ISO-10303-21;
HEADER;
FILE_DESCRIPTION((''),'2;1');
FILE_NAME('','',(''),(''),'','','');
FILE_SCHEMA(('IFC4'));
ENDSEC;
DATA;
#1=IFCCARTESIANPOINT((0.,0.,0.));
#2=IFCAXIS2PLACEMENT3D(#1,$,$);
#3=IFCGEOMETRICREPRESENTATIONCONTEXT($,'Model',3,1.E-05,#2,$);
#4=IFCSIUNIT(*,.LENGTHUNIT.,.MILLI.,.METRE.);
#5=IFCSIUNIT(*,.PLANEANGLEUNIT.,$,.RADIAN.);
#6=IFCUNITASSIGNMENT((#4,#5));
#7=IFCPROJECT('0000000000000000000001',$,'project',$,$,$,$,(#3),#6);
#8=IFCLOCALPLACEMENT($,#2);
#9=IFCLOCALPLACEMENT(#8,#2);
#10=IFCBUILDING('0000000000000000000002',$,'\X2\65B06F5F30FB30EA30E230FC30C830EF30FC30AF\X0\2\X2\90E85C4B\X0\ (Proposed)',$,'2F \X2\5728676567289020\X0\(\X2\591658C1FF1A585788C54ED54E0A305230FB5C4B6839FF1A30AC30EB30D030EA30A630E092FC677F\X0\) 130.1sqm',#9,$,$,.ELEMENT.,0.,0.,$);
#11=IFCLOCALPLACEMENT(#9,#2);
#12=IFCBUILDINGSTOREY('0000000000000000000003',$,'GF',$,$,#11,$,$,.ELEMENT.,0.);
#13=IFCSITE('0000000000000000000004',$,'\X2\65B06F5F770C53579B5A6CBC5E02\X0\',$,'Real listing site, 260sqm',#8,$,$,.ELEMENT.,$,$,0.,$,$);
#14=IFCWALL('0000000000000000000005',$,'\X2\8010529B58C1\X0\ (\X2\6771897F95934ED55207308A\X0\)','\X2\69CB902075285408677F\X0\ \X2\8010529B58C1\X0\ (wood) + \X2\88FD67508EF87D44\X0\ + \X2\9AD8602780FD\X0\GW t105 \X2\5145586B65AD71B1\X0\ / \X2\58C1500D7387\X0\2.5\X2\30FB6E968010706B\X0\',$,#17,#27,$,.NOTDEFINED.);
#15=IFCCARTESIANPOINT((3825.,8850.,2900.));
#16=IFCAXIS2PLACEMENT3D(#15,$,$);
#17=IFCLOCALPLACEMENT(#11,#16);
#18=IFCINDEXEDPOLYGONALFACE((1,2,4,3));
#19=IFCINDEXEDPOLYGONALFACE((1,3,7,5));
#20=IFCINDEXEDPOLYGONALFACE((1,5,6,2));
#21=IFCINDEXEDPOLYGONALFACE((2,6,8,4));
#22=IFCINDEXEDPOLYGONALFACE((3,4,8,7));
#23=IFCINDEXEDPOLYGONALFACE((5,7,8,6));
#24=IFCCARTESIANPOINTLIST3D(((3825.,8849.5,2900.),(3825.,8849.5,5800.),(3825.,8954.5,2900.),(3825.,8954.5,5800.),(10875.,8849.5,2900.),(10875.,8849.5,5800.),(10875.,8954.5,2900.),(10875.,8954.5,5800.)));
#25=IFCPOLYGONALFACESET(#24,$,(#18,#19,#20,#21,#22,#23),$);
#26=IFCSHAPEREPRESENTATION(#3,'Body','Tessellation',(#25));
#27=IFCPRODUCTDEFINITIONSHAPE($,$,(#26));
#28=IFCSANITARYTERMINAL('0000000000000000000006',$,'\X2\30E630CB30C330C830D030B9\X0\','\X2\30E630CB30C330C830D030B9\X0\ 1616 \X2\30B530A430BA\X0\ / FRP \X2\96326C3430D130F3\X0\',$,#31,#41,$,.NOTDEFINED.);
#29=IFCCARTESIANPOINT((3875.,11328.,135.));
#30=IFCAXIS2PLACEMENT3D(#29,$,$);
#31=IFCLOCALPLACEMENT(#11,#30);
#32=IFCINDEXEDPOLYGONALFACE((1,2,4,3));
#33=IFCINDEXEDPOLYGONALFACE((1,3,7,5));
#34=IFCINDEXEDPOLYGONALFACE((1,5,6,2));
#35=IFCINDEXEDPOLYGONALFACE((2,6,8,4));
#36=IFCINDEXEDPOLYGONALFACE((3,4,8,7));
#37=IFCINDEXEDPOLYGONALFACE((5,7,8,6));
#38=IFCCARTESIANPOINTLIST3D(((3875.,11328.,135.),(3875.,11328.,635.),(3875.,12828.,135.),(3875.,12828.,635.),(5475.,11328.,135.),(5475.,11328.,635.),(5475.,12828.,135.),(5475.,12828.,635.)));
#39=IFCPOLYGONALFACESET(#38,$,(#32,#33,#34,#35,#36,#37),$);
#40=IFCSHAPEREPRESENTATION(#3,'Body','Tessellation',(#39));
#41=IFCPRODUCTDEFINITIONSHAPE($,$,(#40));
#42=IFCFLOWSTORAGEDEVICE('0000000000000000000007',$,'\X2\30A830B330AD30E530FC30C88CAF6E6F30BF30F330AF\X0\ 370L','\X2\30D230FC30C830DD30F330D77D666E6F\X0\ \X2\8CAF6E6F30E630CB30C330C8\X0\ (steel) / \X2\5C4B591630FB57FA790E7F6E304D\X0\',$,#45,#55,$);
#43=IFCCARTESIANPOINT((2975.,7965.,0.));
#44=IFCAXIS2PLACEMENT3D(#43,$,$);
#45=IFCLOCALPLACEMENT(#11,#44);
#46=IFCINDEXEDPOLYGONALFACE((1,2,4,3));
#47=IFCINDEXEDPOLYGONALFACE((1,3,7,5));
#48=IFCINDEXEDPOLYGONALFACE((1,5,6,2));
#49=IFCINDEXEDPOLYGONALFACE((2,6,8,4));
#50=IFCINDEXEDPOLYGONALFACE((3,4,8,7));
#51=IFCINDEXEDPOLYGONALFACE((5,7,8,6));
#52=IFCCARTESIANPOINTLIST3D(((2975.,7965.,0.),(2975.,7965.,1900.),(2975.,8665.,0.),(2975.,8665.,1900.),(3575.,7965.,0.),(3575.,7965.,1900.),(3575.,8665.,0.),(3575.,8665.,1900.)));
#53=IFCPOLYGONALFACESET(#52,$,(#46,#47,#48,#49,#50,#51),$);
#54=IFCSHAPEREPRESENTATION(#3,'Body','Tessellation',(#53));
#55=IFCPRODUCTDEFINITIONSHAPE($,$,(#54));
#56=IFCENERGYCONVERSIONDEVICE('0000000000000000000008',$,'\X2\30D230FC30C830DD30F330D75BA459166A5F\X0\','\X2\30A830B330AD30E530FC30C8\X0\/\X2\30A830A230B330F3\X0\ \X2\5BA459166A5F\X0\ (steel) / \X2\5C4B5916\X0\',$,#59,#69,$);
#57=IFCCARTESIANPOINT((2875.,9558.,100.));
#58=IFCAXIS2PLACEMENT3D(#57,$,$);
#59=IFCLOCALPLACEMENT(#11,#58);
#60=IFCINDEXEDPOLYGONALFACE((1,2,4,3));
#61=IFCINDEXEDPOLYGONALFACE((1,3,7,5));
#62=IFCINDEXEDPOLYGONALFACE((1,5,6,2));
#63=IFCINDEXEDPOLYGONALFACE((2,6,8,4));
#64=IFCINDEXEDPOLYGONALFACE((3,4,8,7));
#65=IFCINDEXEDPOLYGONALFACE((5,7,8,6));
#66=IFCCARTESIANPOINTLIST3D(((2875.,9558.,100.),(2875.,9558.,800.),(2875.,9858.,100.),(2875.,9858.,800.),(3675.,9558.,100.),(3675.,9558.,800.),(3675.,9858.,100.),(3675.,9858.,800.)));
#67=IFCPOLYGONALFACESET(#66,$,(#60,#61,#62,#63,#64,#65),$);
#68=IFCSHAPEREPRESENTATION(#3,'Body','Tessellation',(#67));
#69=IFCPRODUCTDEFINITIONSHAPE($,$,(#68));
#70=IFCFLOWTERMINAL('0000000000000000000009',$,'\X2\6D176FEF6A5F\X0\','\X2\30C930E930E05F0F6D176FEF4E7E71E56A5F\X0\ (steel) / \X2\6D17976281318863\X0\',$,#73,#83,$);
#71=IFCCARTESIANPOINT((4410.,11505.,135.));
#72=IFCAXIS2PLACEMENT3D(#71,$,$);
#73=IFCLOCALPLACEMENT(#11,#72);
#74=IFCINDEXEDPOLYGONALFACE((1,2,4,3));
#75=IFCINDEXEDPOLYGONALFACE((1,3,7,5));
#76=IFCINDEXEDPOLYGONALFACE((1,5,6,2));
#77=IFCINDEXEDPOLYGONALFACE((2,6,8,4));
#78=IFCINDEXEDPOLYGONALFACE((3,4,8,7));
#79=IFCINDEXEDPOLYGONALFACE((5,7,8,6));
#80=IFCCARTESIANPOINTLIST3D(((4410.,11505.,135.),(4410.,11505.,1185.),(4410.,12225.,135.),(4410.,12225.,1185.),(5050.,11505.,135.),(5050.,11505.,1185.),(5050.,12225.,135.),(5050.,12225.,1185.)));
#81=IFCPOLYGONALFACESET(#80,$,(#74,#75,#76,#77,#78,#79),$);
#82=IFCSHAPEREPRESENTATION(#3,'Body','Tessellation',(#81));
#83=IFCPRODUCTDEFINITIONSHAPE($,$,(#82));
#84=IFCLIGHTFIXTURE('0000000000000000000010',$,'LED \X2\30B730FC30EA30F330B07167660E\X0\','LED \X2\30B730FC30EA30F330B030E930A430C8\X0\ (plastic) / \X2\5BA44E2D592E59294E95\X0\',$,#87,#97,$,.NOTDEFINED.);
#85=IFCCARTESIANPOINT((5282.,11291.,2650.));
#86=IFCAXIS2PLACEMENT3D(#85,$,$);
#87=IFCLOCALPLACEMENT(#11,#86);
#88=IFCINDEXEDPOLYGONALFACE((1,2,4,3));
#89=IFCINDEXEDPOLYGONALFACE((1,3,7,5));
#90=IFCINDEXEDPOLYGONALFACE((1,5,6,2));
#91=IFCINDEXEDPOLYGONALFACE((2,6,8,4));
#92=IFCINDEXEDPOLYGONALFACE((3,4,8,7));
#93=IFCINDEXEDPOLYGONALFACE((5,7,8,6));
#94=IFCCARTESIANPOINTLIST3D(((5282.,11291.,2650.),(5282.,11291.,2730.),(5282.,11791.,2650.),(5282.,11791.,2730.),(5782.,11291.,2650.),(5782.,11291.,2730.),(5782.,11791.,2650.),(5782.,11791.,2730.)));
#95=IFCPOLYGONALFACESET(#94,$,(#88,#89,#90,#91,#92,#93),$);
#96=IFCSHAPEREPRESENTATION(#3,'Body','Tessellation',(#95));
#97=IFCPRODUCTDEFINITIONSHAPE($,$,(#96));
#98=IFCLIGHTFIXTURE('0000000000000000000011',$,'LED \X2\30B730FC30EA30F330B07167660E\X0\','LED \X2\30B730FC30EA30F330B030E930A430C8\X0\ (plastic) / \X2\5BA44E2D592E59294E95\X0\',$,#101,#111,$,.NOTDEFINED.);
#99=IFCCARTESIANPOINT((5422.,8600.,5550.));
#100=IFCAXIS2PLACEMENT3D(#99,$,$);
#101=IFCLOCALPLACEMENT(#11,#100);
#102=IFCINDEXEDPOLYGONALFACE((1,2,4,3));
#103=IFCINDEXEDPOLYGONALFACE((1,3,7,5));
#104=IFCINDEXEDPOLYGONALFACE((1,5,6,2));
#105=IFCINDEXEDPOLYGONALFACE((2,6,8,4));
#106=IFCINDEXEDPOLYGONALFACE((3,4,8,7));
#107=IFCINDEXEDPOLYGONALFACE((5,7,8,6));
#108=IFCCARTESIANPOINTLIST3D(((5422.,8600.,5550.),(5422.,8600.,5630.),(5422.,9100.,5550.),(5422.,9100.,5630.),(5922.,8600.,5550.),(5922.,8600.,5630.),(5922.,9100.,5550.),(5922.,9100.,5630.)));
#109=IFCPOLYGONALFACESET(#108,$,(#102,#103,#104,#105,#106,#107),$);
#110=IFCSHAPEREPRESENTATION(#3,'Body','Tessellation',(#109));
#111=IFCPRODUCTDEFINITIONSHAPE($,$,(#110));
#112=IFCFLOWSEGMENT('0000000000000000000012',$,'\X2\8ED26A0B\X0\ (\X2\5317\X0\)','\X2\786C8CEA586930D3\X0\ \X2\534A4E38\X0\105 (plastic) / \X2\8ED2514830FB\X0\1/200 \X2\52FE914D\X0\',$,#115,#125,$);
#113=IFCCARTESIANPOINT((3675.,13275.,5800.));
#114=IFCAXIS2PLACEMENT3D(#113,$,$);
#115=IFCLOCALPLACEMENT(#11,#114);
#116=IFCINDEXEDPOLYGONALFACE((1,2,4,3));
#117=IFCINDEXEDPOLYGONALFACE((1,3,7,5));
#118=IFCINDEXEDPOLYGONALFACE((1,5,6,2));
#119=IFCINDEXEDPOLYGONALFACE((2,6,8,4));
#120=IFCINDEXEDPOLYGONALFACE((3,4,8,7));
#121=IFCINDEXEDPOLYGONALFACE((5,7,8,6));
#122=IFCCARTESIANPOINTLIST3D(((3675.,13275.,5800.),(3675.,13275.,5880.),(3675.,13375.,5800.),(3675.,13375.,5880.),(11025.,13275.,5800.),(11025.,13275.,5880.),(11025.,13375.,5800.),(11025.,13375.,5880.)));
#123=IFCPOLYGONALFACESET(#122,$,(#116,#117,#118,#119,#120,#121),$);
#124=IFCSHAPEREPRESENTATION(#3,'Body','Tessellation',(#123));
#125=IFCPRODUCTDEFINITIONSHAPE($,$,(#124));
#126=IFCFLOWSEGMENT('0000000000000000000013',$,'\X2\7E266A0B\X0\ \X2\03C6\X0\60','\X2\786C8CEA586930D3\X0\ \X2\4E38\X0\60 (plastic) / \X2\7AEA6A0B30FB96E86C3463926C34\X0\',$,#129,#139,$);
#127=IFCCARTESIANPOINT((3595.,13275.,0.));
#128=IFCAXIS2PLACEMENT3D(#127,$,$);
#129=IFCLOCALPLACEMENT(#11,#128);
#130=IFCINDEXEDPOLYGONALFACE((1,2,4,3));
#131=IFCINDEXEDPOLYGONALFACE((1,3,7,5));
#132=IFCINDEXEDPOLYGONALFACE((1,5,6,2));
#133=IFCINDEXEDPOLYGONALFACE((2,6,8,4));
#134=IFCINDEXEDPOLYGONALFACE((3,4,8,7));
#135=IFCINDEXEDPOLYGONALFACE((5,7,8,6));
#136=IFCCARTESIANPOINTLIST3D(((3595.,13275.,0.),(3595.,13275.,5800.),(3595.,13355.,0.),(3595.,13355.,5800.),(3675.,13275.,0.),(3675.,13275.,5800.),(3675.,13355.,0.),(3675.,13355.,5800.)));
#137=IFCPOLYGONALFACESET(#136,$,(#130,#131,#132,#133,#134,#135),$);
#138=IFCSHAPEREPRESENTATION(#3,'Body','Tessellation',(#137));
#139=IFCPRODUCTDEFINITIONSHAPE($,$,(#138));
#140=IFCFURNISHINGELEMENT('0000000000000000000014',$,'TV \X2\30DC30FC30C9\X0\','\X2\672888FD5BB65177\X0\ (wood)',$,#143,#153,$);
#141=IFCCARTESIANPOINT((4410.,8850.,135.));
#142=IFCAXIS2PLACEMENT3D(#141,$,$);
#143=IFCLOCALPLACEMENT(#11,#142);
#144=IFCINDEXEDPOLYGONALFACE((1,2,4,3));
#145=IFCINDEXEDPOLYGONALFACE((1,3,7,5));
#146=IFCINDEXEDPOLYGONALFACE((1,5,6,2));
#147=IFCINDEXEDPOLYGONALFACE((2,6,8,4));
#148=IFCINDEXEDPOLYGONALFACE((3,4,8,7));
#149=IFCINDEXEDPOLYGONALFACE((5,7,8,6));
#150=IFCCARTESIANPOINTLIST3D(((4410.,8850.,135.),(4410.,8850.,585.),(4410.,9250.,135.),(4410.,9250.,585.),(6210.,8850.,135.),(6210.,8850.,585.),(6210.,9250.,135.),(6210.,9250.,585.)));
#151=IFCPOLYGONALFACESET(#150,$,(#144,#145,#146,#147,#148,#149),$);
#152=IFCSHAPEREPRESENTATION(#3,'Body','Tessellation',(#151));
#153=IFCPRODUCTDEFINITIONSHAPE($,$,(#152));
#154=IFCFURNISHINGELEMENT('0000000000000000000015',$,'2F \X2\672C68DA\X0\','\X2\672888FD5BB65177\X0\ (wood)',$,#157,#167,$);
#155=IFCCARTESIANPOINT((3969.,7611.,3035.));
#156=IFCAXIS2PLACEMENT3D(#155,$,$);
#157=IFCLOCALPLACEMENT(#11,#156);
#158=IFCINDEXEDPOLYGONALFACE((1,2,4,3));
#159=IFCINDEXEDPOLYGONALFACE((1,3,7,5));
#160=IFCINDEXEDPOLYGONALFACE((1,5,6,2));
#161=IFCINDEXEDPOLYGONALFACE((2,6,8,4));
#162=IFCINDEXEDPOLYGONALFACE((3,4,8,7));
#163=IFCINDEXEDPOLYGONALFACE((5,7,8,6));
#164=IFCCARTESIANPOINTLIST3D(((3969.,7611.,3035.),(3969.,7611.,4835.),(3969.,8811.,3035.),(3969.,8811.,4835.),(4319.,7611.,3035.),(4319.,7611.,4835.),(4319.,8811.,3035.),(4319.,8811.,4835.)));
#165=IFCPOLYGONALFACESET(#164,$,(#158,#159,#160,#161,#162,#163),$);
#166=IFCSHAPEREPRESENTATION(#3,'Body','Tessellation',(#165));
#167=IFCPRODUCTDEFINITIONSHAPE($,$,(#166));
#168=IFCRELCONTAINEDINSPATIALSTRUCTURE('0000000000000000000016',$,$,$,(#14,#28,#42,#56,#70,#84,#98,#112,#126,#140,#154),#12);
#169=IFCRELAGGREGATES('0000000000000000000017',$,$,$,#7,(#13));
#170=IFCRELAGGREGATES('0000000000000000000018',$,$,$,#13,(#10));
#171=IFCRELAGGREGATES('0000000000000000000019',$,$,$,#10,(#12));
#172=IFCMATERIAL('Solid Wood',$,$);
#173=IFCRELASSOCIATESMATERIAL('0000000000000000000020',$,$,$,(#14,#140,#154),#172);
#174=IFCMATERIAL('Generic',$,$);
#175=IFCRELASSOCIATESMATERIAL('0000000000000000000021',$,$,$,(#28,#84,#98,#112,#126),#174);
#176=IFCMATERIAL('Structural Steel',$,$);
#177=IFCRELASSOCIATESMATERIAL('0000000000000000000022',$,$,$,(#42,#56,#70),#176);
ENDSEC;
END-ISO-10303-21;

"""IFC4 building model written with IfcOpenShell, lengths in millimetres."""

from ifc_helpers import new_model, si_unit, frame, frame_2d, origin, place, context, project, spatial, rectangle, extrude, material, element, save


model = new_model("IFC4")

# Units and contexts
model_context = context("Model", 3, precision=1e-05, world=origin())
ifc_project = project(units=[si_unit("LENGTHUNIT", "METRE", prefix="MILLI"), si_unit("PLANEANGLEUNIT", "RADIAN")], contexts=[model_context])

# Site, building, storey
site_placement = place(None, origin())
site = spatial("IfcSite", under=ifc_project, at=site_placement, Name="新潟県南魚沼市", ObjectType="Real listing site, 260sqm", CompositionType="ELEMENT", RefElevation=0.0)
building_placement = place(site_placement, origin())
building = spatial("IfcBuilding", under=site, at=building_placement, Name="新潟・リモートワーク2部屋 (Proposed)", ObjectType="2F 在来木造(外壁：塗装仕上げ・屋根：ガルバリウム鋼板) 130.1sqm", CompositionType="ELEMENT", ElevationOfRefHeight=0.0, ElevationOfTerrain=0.0)
storey_placement = place(building_placement, origin())
storey = spatial("IfcBuildingStorey", under=building, at=storey_placement, Name="GF", CompositionType="ELEMENT", Elevation=0.0)

# Shared definitions
ifc_material_1 = material(Name="Solid Wood")

# Wall
wall_1_placement = place(storey_placement, frame((3825.0, 8850.0, 2900.0)))
element("IfcWall", 1, at=wall_1_placement, inside=storey, material=ifc_material_1, Name="耐力壁 (東西間仕切り)", Description="構造用合板 耐力壁 (wood) + 製材軸組 + 高性能GW t105 充填断熱 / 壁倍率2.5・準耐火", PredefinedType="NOTDEFINED", context=model_context, shape_type="SweptSolid", body=[
    extrude(rectangle(XDim=7050.0, YDim=105.0, at=frame_2d((3525.0, 52.0))), frame((3825.0, 8850.0, 2900.0)), (0.0, 0.0, 1.0), 2900.0),
])

# Sanitary terminal
ifc_material_2 = material(Name="Generic")
sanitary_terminal_placement = place(storey_placement, frame((3875.0, 11328.0, 135.0)))
element("IfcSanitaryTerminal", 2, at=sanitary_terminal_placement, inside=storey, material=ifc_material_2, Name="ユニットバス", Description="ユニットバス 1616 サイズ / FRP 防水パン", PredefinedType="NOTDEFINED", context=model_context, shape_type="SweptSolid", body=[
    extrude(rectangle(XDim=1600.0, YDim=1500.0, at=frame_2d((800.0, 750.0))), frame((3875.0, 11328.0, 135.0)), (0.0, 0.0, 1.0), 500.0),
])

# Flow storage device
ifc_material_3 = material(Name="Structural Steel")
flow_storage_device_placement = place(storey_placement, frame((2975.0, 7965.0, 0.0)))
element("IfcFlowStorageDevice", 3, at=flow_storage_device_placement, inside=storey, material=ifc_material_3, Name="エコキュート貯湯タンク 370L", Description="ヒートポンプ給湯 貯湯ユニット (steel) / 屋外・基礎置き", context=model_context, shape_type="SweptSolid", body=[
    extrude(rectangle(XDim=600.0, YDim=700.0, at=frame_2d((300.0, 350.0))), frame((2975.0, 7965.0, 0.0)), (0.0, 0.0, 1.0), 1900.0),
])

# Energy conversion device
energy_conversion_device_placement = place(storey_placement, frame((2875.0, 9558.0, 100.0)))
element("IfcEnergyConversionDevice", 4, at=energy_conversion_device_placement, inside=storey, material=ifc_material_3, Name="ヒートポンプ室外機", Description="エコキュート/エアコン 室外機 (steel) / 屋外", context=model_context, shape_type="SweptSolid", body=[
    extrude(rectangle(XDim=800.0, YDim=300.0, at=frame_2d((400.0, 150.0))), frame((2875.0, 9558.0, 100.0)), (0.0, 0.0, 1.0), 700.0),
])

# Flow terminal
flow_terminal_placement = place(storey_placement, frame((4410.0, 11505.0, 135.0)))
element("IfcFlowTerminal", 5, at=flow_terminal_placement, inside=storey, material=ifc_material_3, Name="洗濯機", Description="ドラム式洗濯乾燥機 (steel) / 洗面脱衣", context=model_context, shape_type="SweptSolid", body=[
    extrude(rectangle(XDim=640.0, YDim=720.0, at=frame_2d((320.0, 360.0))), frame((4410.0, 11505.0, 135.0)), (0.0, 0.0, 1.0), 1050.0),
])

# Light fixtures
light_fixture_1_placement = place(storey_placement, frame((5282.0, 11291.0, 2650.0)))
element("IfcLightFixture", 6, at=light_fixture_1_placement, inside=storey, material=ifc_material_2, Name="LED シーリング照明", Description="LED シーリングライト (plastic) / 室中央天井", PredefinedType="NOTDEFINED", context=model_context, shape_type="SweptSolid", body=[
    extrude(rectangle(XDim=500.0, YDim=500.0, at=frame_2d((250.0, 250.0))), frame((5282.0, 11291.0, 2650.0)), (0.0, 0.0, 1.0), 80.0),
])
light_fixture_2_placement = place(storey_placement, frame((5422.0, 8600.0, 5550.0)))
element("IfcLightFixture", 7, at=light_fixture_2_placement, inside=storey, material=ifc_material_2, Name="LED シーリング照明", Description="LED シーリングライト (plastic) / 室中央天井", PredefinedType="NOTDEFINED", context=model_context, shape_type="SweptSolid", body=[
    extrude(rectangle(XDim=500.0, YDim=500.0, at=frame_2d((250.0, 250.0))), frame((5422.0, 8600.0, 5550.0)), (0.0, 0.0, 1.0), 80.0),
])

# Flow segments
flow_segment_1_placement = place(storey_placement, frame((3675.0, 13275.0, 5800.0)))
element("IfcFlowSegment", 8, at=flow_segment_1_placement, inside=storey, material=ifc_material_2, Name="軒樋 (北)", Description="硬質塩ビ 半丸105 (plastic) / 軒先・1/200 勾配", context=model_context, shape_type="SweptSolid", body=[
    extrude(rectangle(XDim=7350.0, YDim=100.0, at=frame_2d((3675.0, 50.0))), frame((3675.0, 13275.0, 5800.0)), (0.0, 0.0, 1.0), 80.0),
])
flow_segment_2_placement = place(storey_placement, frame((3595.0, 13275.0, 0.0)))
element("IfcFlowSegment", 9, at=flow_segment_2_placement, inside=storey, material=ifc_material_2, Name="縦樋 φ60", Description="硬質塩ビ 丸60 (plastic) / 竪樋・雨水排水", context=model_context, shape_type="SweptSolid", body=[
    extrude(rectangle(XDim=80.0, YDim=80.0, at=frame_2d((40.0, 40.0))), frame((3595.0, 13275.0, 0.0)), (0.0, 0.0, 1.0), 5800.0),
])

# Furnishing elements
furnishing_1_placement = place(storey_placement, frame((4410.0, 8850.0, 135.0)))
element("IfcFurnishingElement", 10, at=furnishing_1_placement, inside=storey, material=ifc_material_1, Name="TV ボード", Description="木製家具 (wood)", context=model_context, shape_type="SweptSolid", body=[
    extrude(rectangle(XDim=1800.0, YDim=400.0, at=frame_2d((900.0, 200.0))), frame((4410.0, 8850.0, 135.0)), (0.0, 0.0, 1.0), 450.0),
])
furnishing_2_placement = place(storey_placement, frame((3969.0, 7611.0, 3035.0)))
element("IfcFurnishingElement", 11, at=furnishing_2_placement, inside=storey, material=ifc_material_1, Name="2F 本棚", Description="木製家具 (wood)", context=model_context, shape_type="SweptSolid", body=[
    extrude(rectangle(XDim=350.0, YDim=1200.0, at=frame_2d((175.0, 600.0))), frame((3969.0, 7611.0, 3035.0)), (0.0, 0.0, 1.0), 1800.0),
])

save(model, "model.ifc")
